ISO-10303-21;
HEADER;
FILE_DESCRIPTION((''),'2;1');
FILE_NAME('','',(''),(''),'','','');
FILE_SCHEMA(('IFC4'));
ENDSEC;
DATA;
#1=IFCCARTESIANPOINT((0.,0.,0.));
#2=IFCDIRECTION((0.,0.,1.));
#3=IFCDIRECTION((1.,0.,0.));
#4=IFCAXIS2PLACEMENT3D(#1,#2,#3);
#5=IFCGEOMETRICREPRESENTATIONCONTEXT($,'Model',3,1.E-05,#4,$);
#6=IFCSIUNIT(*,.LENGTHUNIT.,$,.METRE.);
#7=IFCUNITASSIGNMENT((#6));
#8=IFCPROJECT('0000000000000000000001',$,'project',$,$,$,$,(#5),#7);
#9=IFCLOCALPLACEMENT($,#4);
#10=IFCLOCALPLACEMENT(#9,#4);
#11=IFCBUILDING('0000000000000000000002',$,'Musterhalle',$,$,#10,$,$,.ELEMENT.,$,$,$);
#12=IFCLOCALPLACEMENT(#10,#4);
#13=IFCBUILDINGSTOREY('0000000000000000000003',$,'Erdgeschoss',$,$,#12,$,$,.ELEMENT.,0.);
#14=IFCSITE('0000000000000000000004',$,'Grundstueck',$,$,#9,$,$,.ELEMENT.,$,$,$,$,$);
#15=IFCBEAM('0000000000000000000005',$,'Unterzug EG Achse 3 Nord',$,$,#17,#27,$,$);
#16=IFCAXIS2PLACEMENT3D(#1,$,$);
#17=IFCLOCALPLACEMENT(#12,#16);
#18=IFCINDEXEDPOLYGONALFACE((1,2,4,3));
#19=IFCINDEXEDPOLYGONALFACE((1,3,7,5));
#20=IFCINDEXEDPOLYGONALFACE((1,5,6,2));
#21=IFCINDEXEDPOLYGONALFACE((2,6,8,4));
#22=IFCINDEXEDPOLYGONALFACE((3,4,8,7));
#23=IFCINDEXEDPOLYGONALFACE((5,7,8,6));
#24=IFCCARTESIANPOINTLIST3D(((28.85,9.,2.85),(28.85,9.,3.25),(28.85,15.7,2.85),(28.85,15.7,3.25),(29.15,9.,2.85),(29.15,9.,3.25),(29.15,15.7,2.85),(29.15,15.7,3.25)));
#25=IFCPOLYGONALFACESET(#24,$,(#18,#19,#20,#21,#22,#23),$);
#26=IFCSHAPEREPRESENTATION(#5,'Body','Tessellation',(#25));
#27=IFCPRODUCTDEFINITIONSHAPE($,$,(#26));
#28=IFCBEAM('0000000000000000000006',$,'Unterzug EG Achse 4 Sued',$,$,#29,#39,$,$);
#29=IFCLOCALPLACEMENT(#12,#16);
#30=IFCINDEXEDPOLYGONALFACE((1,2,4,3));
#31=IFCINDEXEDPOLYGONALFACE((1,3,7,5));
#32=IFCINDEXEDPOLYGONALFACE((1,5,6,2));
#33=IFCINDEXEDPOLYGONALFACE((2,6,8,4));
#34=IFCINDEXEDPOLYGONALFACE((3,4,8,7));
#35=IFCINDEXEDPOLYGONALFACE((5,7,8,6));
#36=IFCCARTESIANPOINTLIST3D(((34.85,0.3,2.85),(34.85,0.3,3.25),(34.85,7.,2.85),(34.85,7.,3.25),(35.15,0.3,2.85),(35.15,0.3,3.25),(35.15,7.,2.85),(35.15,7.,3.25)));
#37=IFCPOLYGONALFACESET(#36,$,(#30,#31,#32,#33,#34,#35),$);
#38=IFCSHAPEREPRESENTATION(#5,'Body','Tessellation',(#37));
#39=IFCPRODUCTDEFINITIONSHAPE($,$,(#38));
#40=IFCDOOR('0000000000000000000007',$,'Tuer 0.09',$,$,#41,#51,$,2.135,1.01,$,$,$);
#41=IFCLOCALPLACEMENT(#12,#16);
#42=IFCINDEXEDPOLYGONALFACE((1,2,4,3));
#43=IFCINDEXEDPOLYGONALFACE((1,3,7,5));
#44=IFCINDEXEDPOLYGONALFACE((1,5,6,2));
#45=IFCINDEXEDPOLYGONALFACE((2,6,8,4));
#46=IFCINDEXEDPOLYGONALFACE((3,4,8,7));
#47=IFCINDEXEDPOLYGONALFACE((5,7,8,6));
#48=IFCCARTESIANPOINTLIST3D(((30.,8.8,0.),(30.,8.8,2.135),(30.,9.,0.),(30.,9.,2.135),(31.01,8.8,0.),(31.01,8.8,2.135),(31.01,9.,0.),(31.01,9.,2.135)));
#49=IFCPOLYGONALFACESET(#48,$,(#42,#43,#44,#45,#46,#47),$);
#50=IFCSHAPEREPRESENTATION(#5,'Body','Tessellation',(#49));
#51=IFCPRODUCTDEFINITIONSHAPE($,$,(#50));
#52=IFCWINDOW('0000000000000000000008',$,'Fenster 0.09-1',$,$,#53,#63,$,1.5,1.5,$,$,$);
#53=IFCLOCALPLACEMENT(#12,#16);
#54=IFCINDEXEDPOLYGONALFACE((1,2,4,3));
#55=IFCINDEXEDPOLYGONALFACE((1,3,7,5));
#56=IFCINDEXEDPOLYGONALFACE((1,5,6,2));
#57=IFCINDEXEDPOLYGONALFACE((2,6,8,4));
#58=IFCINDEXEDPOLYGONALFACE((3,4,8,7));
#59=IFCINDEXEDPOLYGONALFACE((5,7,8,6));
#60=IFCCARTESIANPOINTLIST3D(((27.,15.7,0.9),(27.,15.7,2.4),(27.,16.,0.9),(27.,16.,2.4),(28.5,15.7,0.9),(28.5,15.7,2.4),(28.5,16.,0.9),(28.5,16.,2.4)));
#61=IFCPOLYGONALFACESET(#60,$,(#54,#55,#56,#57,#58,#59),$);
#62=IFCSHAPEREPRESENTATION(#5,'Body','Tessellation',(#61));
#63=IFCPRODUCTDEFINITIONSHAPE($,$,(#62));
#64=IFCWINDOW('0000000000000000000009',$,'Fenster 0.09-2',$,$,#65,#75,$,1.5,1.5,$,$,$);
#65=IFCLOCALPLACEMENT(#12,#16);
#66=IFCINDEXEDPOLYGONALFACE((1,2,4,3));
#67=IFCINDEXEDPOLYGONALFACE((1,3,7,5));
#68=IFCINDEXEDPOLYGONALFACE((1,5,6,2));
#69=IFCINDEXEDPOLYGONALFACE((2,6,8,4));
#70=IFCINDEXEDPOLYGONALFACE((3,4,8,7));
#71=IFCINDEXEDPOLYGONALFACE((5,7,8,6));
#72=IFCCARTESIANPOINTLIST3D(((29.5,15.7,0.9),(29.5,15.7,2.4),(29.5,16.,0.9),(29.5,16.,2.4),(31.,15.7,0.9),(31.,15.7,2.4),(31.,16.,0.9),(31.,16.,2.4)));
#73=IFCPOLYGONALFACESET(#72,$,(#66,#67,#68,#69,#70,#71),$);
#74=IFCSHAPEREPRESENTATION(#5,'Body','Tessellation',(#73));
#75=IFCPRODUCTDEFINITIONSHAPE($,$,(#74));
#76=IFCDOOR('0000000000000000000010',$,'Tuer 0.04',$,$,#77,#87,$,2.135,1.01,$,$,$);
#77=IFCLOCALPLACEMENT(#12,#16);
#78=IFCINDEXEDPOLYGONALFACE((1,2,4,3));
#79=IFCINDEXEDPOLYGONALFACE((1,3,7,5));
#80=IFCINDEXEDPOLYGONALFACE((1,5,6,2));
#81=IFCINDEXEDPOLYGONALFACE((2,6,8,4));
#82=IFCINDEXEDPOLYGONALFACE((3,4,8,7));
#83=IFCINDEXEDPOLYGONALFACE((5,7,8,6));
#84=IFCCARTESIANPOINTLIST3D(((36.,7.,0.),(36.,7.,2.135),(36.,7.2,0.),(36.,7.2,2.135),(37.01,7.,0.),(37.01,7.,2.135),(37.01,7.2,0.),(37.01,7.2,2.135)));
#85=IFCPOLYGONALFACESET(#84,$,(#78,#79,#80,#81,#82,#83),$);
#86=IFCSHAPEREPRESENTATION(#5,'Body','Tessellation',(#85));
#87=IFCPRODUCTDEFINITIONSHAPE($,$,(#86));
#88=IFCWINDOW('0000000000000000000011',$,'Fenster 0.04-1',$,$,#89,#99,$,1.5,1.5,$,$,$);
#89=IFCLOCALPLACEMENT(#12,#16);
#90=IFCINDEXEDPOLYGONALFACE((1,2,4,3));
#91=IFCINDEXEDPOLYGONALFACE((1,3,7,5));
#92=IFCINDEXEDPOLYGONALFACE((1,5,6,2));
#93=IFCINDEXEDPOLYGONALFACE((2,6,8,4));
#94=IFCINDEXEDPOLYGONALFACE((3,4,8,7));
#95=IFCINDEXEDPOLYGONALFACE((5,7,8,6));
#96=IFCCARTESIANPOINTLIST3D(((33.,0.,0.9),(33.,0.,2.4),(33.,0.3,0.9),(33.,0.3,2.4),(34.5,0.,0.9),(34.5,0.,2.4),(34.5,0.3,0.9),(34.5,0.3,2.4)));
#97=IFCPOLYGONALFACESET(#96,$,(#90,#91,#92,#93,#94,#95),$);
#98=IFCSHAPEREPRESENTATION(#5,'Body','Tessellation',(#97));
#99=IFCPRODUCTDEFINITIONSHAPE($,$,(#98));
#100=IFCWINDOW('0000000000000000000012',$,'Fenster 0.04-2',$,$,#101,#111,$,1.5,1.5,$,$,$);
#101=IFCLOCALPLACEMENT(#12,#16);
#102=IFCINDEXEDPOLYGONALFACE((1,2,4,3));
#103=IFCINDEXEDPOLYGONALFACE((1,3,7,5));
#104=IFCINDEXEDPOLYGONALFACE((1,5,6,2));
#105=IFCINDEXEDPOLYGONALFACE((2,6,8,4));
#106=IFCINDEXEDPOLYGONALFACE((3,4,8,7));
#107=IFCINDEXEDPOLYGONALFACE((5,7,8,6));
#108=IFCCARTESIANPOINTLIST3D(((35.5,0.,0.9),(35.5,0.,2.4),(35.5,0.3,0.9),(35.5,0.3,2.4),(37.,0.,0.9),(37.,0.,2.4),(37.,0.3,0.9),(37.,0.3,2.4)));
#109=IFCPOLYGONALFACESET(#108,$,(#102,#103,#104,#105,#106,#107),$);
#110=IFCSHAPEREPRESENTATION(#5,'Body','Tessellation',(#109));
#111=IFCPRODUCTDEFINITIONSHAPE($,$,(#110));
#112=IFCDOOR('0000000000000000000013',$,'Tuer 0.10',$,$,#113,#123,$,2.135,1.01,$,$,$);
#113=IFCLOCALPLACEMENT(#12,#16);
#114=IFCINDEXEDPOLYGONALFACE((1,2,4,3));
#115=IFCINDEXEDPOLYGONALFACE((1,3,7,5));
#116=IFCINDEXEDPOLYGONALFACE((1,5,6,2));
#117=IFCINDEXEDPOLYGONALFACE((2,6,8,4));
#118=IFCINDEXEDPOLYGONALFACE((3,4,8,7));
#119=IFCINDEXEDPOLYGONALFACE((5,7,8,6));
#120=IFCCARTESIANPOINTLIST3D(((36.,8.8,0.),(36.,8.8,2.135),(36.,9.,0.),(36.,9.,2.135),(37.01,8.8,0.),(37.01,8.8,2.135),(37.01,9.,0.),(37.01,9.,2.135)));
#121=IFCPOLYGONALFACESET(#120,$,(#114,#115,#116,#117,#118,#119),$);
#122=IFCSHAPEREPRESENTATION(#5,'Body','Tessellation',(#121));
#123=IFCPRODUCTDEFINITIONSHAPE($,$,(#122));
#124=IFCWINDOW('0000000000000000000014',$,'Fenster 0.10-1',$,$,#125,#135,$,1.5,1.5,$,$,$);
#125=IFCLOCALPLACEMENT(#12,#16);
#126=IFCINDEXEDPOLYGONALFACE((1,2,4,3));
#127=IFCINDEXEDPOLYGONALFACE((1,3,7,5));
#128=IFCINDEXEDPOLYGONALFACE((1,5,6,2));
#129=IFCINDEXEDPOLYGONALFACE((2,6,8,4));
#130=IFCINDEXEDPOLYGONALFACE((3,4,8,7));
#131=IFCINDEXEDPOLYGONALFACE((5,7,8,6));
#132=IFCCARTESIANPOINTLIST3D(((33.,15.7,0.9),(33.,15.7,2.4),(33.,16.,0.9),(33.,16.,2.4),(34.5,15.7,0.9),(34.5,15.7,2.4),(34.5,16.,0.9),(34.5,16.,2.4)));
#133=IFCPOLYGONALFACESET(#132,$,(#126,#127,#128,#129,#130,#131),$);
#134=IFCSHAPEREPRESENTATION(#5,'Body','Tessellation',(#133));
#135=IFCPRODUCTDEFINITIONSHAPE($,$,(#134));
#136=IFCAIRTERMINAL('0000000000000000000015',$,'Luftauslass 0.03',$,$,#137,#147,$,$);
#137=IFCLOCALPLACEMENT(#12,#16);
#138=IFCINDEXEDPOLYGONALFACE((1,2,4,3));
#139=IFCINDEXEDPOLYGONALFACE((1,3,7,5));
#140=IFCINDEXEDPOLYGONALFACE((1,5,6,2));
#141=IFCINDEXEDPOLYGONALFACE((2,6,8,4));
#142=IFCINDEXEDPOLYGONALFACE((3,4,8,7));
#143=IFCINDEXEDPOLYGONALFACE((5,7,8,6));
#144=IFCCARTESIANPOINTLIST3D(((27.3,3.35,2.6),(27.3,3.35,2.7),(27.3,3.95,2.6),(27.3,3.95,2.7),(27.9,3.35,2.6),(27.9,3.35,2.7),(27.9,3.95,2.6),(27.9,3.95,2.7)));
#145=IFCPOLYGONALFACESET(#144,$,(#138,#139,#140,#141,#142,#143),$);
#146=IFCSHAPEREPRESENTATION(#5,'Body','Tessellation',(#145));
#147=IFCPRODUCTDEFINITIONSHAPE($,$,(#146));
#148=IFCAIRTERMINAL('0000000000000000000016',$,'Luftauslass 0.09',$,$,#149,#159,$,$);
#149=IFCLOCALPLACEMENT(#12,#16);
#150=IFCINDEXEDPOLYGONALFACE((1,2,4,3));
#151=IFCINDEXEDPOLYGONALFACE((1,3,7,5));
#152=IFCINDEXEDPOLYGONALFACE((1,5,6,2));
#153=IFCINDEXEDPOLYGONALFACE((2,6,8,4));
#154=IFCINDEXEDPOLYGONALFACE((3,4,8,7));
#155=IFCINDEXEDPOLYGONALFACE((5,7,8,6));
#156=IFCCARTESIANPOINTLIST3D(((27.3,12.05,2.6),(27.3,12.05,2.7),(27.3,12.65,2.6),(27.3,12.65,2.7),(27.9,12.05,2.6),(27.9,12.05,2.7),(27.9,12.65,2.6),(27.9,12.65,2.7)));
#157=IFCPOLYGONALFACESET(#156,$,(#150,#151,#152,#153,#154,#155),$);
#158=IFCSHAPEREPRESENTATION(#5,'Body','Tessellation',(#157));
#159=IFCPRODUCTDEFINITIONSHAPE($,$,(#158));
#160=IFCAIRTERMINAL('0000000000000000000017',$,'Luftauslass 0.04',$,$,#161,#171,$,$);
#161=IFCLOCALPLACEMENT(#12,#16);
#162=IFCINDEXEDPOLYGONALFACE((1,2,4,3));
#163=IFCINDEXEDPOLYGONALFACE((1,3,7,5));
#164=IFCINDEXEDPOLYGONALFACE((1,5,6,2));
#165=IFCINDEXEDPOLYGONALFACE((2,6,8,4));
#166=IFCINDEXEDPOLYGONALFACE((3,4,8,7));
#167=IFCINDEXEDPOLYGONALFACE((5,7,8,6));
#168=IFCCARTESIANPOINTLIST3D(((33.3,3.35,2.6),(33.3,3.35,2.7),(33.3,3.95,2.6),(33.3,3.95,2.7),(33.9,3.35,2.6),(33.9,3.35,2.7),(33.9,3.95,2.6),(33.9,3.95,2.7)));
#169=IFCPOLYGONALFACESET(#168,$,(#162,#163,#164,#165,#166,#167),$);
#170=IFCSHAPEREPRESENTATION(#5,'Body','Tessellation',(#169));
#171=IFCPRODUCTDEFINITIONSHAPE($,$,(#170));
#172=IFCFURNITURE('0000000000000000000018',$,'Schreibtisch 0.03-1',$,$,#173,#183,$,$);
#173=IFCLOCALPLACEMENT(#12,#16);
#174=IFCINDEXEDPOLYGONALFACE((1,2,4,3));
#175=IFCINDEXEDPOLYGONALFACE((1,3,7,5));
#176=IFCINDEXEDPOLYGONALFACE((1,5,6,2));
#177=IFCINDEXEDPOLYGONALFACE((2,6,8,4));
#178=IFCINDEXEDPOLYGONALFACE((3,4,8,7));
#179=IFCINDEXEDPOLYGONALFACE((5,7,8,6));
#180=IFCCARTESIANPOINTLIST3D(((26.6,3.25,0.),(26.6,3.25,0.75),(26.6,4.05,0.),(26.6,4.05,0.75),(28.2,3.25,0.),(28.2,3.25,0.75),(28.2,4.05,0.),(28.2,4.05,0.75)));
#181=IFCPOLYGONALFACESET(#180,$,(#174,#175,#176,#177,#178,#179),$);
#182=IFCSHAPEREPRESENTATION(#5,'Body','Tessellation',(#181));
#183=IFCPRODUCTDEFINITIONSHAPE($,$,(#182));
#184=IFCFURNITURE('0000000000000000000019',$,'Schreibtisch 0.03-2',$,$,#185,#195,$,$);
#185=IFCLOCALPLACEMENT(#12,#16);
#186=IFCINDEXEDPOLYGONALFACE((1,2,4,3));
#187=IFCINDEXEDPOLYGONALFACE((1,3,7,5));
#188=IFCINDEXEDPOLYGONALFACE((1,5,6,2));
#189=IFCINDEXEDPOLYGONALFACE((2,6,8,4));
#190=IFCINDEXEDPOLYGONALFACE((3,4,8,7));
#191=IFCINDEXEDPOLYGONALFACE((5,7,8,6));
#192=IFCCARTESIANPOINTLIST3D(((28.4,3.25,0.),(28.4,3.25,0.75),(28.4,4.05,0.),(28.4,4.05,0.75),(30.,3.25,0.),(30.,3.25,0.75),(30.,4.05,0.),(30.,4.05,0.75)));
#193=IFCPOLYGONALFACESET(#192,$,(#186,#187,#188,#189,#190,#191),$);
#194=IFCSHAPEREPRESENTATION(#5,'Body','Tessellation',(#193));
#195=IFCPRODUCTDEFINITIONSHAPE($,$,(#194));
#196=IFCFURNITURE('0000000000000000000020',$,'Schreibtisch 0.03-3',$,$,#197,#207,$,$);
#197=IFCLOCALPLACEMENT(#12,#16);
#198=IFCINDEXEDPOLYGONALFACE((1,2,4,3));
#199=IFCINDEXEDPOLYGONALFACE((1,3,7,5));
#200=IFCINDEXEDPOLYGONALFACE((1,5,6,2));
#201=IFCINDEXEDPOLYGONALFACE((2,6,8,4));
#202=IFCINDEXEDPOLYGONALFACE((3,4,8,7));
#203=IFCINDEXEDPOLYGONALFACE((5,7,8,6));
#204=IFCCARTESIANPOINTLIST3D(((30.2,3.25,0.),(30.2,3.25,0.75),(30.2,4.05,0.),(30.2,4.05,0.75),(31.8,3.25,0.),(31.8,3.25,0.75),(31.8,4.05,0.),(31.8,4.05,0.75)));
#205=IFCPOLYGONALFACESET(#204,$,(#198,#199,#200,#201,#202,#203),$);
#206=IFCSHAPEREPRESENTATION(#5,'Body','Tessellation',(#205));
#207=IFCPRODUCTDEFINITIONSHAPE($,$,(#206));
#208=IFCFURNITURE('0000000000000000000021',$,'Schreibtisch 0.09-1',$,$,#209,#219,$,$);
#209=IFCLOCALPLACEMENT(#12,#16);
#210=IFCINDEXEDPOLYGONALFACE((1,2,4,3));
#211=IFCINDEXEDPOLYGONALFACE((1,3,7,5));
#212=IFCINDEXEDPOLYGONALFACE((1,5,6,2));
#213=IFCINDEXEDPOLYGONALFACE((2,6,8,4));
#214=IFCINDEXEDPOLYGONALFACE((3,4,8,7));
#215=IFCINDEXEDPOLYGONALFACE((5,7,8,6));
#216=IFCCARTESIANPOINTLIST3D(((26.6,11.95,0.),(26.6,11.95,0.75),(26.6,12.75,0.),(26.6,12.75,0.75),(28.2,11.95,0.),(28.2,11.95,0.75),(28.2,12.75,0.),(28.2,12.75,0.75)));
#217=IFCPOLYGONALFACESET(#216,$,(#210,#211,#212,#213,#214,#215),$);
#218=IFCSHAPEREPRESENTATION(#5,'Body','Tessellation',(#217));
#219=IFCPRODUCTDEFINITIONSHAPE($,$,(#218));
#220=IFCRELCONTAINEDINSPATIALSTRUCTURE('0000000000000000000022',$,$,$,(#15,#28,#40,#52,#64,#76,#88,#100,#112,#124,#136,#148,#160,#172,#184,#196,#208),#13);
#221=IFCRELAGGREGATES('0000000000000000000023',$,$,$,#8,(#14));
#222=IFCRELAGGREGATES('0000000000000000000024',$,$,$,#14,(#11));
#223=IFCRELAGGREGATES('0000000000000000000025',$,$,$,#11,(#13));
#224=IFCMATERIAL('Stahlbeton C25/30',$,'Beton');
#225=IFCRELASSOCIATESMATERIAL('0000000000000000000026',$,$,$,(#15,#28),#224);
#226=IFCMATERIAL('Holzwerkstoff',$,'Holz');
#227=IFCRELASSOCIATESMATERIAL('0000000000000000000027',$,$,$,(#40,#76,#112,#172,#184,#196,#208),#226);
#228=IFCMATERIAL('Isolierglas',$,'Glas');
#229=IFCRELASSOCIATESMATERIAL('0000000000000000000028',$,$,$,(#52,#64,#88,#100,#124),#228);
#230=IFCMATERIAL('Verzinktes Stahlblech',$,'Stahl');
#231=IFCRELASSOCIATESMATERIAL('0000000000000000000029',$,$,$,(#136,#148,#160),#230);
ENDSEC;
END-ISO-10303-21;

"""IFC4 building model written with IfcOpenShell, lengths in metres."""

from ifc_helpers import new_model, si_unit, frame, origin_with_axes, origin_2d, place, context, project, spatial, rectangle, extrude, material, element, save


model = new_model("IFC4")

# Units and contexts
model_context = context("Model", 3, precision=1e-05, world=origin_with_axes())
ifc_project = project(units=[si_unit("LENGTHUNIT", "METRE")], contexts=[model_context])

# Site, building, storey
site_placement = place(None, origin_with_axes())
site = spatial("IfcSite", under=ifc_project, at=site_placement, Name="Grundstueck", CompositionType="ELEMENT")
building_placement = place(site_placement, origin_with_axes())
building = spatial("IfcBuilding", under=site, at=building_placement, Name="Musterhalle", CompositionType="ELEMENT")
storey_placement = place(building_placement, origin_with_axes())
storey = spatial("IfcBuildingStorey", under=building, at=storey_placement, Name="Erdgeschoss", CompositionType="ELEMENT", Elevation=0.0)

# Beams
ifc_material_1 = material(Name="Stahlbeton C25/30", Category="Beton")
placement = place(storey_placement, origin_with_axes())
element("IfcBeam", 1, at=placement, inside=storey, material=ifc_material_1, Name="Unterzug EG Achse 3 Nord", context=model_context, shape_type="SweptSolid", body=[
    extrude(rectangle(XDim=0.3, YDim=6.7, at=origin_2d()), frame((29.0, 12.35, 2.85), z_axis=(0.0, 0.0, 1.0), x_axis=(1.0, 0.0, 0.0)), (0.0, 0.0, 1.0), 0.4),
])
element("IfcBeam", 2, at=placement, inside=storey, material=ifc_material_1, Name="Unterzug EG Achse 4 Sued", context=model_context, shape_type="SweptSolid", body=[
    extrude(rectangle(XDim=0.3, YDim=6.7, at=origin_2d()), frame((35.0, 3.65, 2.85), z_axis=(0.0, 0.0, 1.0), x_axis=(1.0, 0.0, 0.0)), (0.0, 0.0, 1.0), 0.4),
])

# Door
ifc_material_2 = material(Name="Holzwerkstoff", Category="Holz")
element("IfcDoor", 3, at=placement, inside=storey, material=ifc_material_2, Name="Tuer 0.09", OverallHeight=2.135, OverallWidth=1.01, context=model_context, shape_type="SweptSolid", body=[
    extrude(rectangle(XDim=1.01, YDim=0.2, at=origin_2d()), frame((30.505, 8.9, 0.0), z_axis=(0.0, 0.0, 1.0), x_axis=(1.0, 0.0, 0.0)), (0.0, 0.0, 1.0), 2.135),
])

# Windows
ifc_material_3 = material(Name="Isolierglas", Category="Glas")
element("IfcWindow", 4, at=placement, inside=storey, material=ifc_material_3, Name="Fenster 0.09-1", OverallHeight=1.5, OverallWidth=1.5, context=model_context, shape_type="SweptSolid", body=[
    extrude(rectangle(XDim=1.5, YDim=0.3, at=origin_2d()), frame((27.75, 15.85, 0.9), z_axis=(0.0, 0.0, 1.0), x_axis=(1.0, 0.0, 0.0)), (0.0, 0.0, 1.0), 1.5),
])
element("IfcWindow", 5, at=placement, inside=storey, material=ifc_material_3, Name="Fenster 0.09-2", OverallHeight=1.5, OverallWidth=1.5, context=model_context, shape_type="SweptSolid", body=[
    extrude(rectangle(XDim=1.5, YDim=0.3, at=origin_2d()), frame((30.25, 15.85, 0.9), z_axis=(0.0, 0.0, 1.0), x_axis=(1.0, 0.0, 0.0)), (0.0, 0.0, 1.0), 1.5),
])

# Door
element("IfcDoor", 6, at=placement, inside=storey, material=ifc_material_2, Name="Tuer 0.04", OverallHeight=2.135, OverallWidth=1.01, context=model_context, shape_type="SweptSolid", body=[
    extrude(rectangle(XDim=1.01, YDim=0.2, at=origin_2d()), frame((36.505, 7.1, 0.0), z_axis=(0.0, 0.0, 1.0), x_axis=(1.0, 0.0, 0.0)), (0.0, 0.0, 1.0), 2.135),
])

# Windows
element("IfcWindow", 7, at=placement, inside=storey, material=ifc_material_3, Name="Fenster 0.04-1", OverallHeight=1.5, OverallWidth=1.5, context=model_context, shape_type="SweptSolid", body=[
    extrude(rectangle(XDim=1.5, YDim=0.3, at=origin_2d()), frame((33.75, 0.15, 0.9), z_axis=(0.0, 0.0, 1.0), x_axis=(1.0, 0.0, 0.0)), (0.0, 0.0, 1.0), 1.5),
])
element("IfcWindow", 8, at=placement, inside=storey, material=ifc_material_3, Name="Fenster 0.04-2", OverallHeight=1.5, OverallWidth=1.5, context=model_context, shape_type="SweptSolid", body=[
    extrude(rectangle(XDim=1.5, YDim=0.3, at=origin_2d()), frame((36.25, 0.15, 0.9), z_axis=(0.0, 0.0, 1.0), x_axis=(1.0, 0.0, 0.0)), (0.0, 0.0, 1.0), 1.5),
])

# Door
element("IfcDoor", 9, at=placement, inside=storey, material=ifc_material_2, Name="Tuer 0.10", OverallHeight=2.135, OverallWidth=1.01, context=model_context, shape_type="SweptSolid", body=[
    extrude(rectangle(XDim=1.01, YDim=0.2, at=origin_2d()), frame((36.505, 8.9, 0.0), z_axis=(0.0, 0.0, 1.0), x_axis=(1.0, 0.0, 0.0)), (0.0, 0.0, 1.0), 2.135),
])

# Window
element("IfcWindow", 10, at=placement, inside=storey, material=ifc_material_3, Name="Fenster 0.10-1", OverallHeight=1.5, OverallWidth=1.5, context=model_context, shape_type="SweptSolid", body=[
    extrude(rectangle(XDim=1.5, YDim=0.3, at=origin_2d()), frame((33.75, 15.85, 0.9), z_axis=(0.0, 0.0, 1.0), x_axis=(1.0, 0.0, 0.0)), (0.0, 0.0, 1.0), 1.5),
])

# Air terminals
ifc_material_4 = material(Name="Verzinktes Stahlblech", Category="Stahl")
element("IfcAirTerminal", 11, at=placement, inside=storey, material=ifc_material_4, Name="Luftauslass 0.03", context=model_context, shape_type="SweptSolid", body=[
    extrude(rectangle(XDim=0.6, YDim=0.6, at=origin_2d()), frame((27.6, 3.65, 2.6), z_axis=(0.0, 0.0, 1.0), x_axis=(1.0, 0.0, 0.0)), (0.0, 0.0, 1.0), 0.1),
])
element("IfcAirTerminal", 12, at=placement, inside=storey, material=ifc_material_4, Name="Luftauslass 0.09", context=model_context, shape_type="SweptSolid", body=[
    extrude(rectangle(XDim=0.6, YDim=0.6, at=origin_2d()), frame((27.6, 12.35, 2.6), z_axis=(0.0, 0.0, 1.0), x_axis=(1.0, 0.0, 0.0)), (0.0, 0.0, 1.0), 0.1),
])
element("IfcAirTerminal", 13, at=placement, inside=storey, material=ifc_material_4, Name="Luftauslass 0.04", context=model_context, shape_type="SweptSolid", body=[
    extrude(rectangle(XDim=0.6, YDim=0.6, at=origin_2d()), frame((33.6, 3.65, 2.6), z_axis=(0.0, 0.0, 1.0), x_axis=(1.0, 0.0, 0.0)), (0.0, 0.0, 1.0), 0.1),
])

# Furniture
element("IfcFurniture", 14, at=placement, inside=storey, material=ifc_material_2, Name="Schreibtisch 0.03-1", context=model_context, shape_type="SweptSolid", body=[
    extrude(rectangle(XDim=1.6, YDim=0.8, at=origin_2d()), frame((27.4, 3.65, 0.0), z_axis=(0.0, 0.0, 1.0), x_axis=(1.0, 0.0, 0.0)), (0.0, 0.0, 1.0), 0.75),
])
element("IfcFurniture", 15, at=placement, inside=storey, material=ifc_material_2, Name="Schreibtisch 0.03-2", context=model_context, shape_type="SweptSolid", body=[
    extrude(rectangle(XDim=1.6, YDim=0.8, at=origin_2d()), frame((29.2, 3.65, 0.0), z_axis=(0.0, 0.0, 1.0), x_axis=(1.0, 0.0, 0.0)), (0.0, 0.0, 1.0), 0.75),
])
element("IfcFurniture", 16, at=placement, inside=storey, material=ifc_material_2, Name="Schreibtisch 0.03-3", context=model_context, shape_type="SweptSolid", body=[
    extrude(rectangle(XDim=1.6, YDim=0.8, at=origin_2d()), frame((31.0, 3.65, 0.0), z_axis=(0.0, 0.0, 1.0), x_axis=(1.0, 0.0, 0.0)), (0.0, 0.0, 1.0), 0.75),
])
element("IfcFurniture", 17, at=placement, inside=storey, material=ifc_material_2, Name="Schreibtisch 0.09-1", context=model_context, shape_type="SweptSolid", body=[
    extrude(rectangle(XDim=1.6, YDim=0.8, at=origin_2d()), frame((27.4, 12.35, 0.0), z_axis=(0.0, 0.0, 1.0), x_axis=(1.0, 0.0, 0.0)), (0.0, 0.0, 1.0), 0.75),
])

save(model, "model.ifc")
